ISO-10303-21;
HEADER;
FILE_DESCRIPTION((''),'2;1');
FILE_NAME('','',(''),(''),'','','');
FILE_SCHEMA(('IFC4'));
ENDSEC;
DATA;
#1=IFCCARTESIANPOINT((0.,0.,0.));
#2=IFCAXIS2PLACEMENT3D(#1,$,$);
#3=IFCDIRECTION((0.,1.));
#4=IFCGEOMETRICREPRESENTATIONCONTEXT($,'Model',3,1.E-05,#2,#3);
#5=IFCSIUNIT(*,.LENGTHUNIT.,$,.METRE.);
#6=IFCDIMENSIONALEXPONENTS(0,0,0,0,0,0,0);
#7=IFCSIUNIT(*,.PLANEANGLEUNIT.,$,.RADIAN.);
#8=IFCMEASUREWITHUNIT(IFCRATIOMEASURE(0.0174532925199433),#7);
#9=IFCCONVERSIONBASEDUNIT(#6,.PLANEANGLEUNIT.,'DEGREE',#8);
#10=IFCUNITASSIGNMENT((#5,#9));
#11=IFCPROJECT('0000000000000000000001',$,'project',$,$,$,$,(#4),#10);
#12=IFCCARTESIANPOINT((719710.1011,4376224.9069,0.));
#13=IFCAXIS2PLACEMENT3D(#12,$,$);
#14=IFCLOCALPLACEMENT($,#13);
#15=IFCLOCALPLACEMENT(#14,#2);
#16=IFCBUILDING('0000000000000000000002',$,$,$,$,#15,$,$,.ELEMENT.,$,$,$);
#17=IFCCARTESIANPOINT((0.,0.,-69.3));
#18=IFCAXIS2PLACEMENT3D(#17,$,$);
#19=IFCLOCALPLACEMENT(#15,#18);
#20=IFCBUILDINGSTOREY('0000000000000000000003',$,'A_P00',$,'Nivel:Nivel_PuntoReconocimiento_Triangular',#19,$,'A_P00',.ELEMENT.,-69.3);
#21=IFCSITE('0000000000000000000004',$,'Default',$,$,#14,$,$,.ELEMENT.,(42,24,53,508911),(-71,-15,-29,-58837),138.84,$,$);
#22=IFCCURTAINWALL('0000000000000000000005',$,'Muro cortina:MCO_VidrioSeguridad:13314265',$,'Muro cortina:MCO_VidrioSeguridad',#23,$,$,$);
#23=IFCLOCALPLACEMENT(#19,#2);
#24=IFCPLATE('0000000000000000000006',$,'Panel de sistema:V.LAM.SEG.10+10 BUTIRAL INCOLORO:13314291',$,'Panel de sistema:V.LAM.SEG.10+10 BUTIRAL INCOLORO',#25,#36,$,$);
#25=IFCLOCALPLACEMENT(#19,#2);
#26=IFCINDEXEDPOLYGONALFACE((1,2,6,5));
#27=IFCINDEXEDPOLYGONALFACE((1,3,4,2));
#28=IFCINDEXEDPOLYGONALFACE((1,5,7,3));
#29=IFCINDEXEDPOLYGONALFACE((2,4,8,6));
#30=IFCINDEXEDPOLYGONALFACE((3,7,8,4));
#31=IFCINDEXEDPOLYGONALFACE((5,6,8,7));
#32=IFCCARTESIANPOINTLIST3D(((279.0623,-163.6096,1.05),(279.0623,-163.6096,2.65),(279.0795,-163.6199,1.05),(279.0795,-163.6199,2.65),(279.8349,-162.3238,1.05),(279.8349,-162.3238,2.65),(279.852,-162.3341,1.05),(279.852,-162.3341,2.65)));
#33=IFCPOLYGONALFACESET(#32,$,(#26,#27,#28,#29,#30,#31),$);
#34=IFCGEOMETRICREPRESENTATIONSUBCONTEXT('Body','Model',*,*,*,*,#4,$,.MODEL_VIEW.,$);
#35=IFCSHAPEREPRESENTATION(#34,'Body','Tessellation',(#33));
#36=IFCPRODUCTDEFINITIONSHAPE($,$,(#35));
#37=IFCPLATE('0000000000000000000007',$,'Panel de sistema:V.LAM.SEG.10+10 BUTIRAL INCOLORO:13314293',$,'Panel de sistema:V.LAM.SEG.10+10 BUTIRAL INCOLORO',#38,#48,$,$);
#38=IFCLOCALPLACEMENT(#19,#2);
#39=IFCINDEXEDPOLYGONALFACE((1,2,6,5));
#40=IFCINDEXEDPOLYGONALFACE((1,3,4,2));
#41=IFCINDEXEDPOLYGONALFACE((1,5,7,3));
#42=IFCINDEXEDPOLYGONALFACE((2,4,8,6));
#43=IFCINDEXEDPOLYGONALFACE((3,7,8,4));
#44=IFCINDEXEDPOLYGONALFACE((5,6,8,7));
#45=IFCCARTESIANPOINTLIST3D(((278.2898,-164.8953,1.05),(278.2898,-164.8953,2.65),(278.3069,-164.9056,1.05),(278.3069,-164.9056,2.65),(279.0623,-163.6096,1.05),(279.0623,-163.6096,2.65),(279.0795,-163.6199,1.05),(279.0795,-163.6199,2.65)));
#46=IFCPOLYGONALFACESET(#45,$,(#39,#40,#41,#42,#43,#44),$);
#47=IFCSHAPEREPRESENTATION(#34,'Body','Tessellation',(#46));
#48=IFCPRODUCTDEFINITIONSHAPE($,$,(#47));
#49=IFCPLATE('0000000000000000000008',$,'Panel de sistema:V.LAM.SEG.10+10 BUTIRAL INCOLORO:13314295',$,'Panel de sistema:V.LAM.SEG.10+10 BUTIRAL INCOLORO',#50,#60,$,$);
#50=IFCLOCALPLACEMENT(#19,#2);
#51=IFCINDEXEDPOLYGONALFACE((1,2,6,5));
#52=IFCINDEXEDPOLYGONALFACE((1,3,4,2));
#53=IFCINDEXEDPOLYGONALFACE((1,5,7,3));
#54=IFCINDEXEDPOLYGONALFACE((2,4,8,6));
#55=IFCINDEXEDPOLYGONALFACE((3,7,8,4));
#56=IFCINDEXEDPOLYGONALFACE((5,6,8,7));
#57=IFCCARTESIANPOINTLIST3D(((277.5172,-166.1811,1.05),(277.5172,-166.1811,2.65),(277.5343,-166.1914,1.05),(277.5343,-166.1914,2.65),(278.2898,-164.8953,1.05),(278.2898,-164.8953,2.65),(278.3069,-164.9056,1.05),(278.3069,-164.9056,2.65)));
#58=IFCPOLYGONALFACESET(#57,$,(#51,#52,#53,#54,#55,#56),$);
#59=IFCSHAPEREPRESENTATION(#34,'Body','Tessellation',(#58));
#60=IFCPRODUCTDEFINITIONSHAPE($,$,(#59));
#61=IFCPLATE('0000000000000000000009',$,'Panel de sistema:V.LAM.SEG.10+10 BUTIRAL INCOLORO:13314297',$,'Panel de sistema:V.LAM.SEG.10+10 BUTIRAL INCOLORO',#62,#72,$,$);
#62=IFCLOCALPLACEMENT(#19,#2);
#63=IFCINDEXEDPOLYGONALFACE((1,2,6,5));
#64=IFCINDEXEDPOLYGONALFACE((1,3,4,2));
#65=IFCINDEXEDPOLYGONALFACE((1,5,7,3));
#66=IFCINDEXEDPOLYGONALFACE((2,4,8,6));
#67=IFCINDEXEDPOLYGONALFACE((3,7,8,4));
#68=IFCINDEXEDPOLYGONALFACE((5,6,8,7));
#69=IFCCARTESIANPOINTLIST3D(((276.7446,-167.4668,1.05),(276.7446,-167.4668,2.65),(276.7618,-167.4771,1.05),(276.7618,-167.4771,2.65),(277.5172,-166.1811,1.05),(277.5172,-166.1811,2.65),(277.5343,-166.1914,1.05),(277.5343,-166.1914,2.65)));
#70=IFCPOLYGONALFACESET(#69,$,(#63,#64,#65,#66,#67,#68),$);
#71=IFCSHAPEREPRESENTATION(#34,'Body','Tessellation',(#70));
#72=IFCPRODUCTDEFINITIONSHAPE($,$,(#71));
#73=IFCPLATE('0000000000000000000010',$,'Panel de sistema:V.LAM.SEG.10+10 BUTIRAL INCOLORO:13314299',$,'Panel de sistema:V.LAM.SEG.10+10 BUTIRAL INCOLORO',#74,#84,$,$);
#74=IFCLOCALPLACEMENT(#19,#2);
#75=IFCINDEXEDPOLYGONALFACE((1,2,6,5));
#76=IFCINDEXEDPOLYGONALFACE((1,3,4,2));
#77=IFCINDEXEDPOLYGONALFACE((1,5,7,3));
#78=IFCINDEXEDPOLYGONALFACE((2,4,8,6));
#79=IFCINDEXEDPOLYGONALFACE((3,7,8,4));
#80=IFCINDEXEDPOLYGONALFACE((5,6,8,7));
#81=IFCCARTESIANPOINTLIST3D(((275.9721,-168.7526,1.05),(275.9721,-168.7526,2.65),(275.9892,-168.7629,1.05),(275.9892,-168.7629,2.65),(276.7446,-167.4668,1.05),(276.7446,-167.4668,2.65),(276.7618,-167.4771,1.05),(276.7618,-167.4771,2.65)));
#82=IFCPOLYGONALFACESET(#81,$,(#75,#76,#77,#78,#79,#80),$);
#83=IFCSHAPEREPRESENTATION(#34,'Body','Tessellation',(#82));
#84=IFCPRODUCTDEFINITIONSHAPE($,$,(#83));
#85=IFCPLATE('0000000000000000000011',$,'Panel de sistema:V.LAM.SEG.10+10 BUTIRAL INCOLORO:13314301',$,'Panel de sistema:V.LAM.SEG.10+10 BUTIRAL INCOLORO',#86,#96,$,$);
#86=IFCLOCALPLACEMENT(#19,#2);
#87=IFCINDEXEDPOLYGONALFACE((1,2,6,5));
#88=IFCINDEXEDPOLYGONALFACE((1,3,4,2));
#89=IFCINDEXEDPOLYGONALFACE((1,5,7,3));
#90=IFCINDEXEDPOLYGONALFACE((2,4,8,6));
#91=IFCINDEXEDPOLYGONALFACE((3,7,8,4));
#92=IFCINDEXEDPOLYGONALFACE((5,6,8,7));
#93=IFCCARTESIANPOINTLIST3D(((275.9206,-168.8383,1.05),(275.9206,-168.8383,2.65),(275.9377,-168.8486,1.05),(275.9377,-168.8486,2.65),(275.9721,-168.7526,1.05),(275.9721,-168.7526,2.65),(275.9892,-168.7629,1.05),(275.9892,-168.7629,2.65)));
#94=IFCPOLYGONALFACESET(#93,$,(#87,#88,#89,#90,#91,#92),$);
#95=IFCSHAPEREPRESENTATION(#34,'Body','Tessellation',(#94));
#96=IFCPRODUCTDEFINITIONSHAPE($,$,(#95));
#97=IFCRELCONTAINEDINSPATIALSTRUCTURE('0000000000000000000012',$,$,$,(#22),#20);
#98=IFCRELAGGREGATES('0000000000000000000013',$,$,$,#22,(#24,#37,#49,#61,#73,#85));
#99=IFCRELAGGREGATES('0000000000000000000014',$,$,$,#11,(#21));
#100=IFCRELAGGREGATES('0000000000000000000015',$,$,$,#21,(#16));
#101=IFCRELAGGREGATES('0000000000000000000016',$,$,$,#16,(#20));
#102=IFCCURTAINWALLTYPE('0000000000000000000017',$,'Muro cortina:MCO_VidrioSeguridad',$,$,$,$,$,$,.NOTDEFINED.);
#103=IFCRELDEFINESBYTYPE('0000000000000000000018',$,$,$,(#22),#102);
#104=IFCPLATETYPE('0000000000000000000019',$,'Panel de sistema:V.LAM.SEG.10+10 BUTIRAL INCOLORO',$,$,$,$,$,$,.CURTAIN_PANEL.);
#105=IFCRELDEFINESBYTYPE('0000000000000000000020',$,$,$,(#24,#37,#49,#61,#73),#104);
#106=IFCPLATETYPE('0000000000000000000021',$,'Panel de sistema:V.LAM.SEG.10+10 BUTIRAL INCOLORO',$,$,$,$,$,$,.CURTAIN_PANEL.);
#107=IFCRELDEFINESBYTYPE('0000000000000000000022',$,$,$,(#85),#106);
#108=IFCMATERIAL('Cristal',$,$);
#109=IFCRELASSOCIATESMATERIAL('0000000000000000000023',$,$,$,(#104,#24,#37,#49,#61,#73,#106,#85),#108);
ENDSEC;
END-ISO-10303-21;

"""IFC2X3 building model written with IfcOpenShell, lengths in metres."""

from ifc_helpers import new_model, entity, si_unit, converted_unit, direction, frame, frame_2d, origin, origin_2d_with_axis, place, context, subcontext, project, spatial, rectangle, extrude, source, transform, mapped, material, type_object, type_shapes, element, aggregate, save


model = new_model("IFC2X3")

# Units and contexts
model_context = context("Model", 3, precision=1e-05, world=origin(), true_north=direction((0.0, 1.0)))
body_context = subcontext(model_context, "Body", "Model", "MODEL_VIEW")
ifc_project = project(units=[si_unit("LENGTHUNIT", "METRE"), converted_unit("PLANEANGLEUNIT", "DEGREE", entity("IfcRatioMeasure", 0.0174532925199433), si_unit("PLANEANGLEUNIT", "RADIAN"), dimensions=[0, 0, 0, 0, 0, 0, 0])], contexts=[model_context])

# Site, building, storey
site_placement = place(None, frame((719710.1011, 4376224.9069, 0.0)))
site = spatial("IfcSite", under=ifc_project, at=site_placement, Name="Default", CompositionType="ELEMENT", RefLatitude=(42, 24, 53, 508911), RefLongitude=(-71, -15, -29, -58837), RefElevation=138.84)
building_placement = place(site_placement, origin())
building = spatial("IfcBuilding", under=site, at=building_placement, CompositionType="ELEMENT")
storey_placement = place(building_placement, frame((0.0, 0.0, -69.3)))
storey = spatial("IfcBuildingStorey", under=building, at=storey_placement, Name="A_P00", ObjectType="Nivel:Nivel_PuntoReconocimiento_Triangular", LongName="A_P00", CompositionType="ELEMENT", Elevation=-69.3)

# Curtain wall, plates
curtain_wall_type = type_object("IfcCurtainWallType", Name="Muro cortina:MCO_VidrioSeguridad", PredefinedType="NOTDEFINED")
ifc_material_1 = material(Name="Cristal")
curtain_wall_1_placement = place(storey_placement, frame((0.0, 0.0, 69.3)))
curtain_wall_1 = element("IfcCurtainWall", 1, at=curtain_wall_1_placement, inside=storey, type_object=curtain_wall_type, Name="Muro cortina:MCO_VidrioSeguridad:13314265", ObjectType="Muro cortina:MCO_VidrioSeguridad")
plate_type_1 = type_object("IfcPlateType", Name="Panel de sistema:V.LAM.SEG.10+10 BUTIRAL INCOLORO", PredefinedType="CURTAIN_PANEL", material=ifc_material_1)
shared_shape_1 = source(origin(), body_context, "Body", "SweptSolid", [
    extrude(rectangle(XDim=0.02, YDim=1.5, at=frame_2d((0.0, 0.0), x_axis=(1.0, 0.0))), frame((0.0, 0.0, 0.0), z_axis=(0.0, 0.0, 1.0), x_axis=(0.0, 1.0, 0.0)), (0.0, 0.0, 1.0), 1.6),
])
type_shapes(plate_type_1, [shared_shape_1])
plate_1_placement = place(curtain_wall_1_placement, frame((279.4572, -162.9718, -68.25), z_axis=(0.0, 0.0, 1.0), x_axis=(-0.515038, -0.857167, 0.0)))
plate_1 = element("IfcPlate", 2, at=plate_1_placement, type_object=plate_type_1, material=ifc_material_1, Name="Panel de sistema:V.LAM.SEG.10+10 BUTIRAL INCOLORO:13314291", ObjectType="Panel de sistema:V.LAM.SEG.10+10 BUTIRAL INCOLORO", context=body_context, shape_type="MappedRepresentation", body=[
    mapped(shared_shape_1, transform((0.0, 0.0, 0.0), scale=1.0)),
])
plate_2_placement = place(curtain_wall_1_placement, frame((278.6846, -164.2576, -68.25), z_axis=(0.0, 0.0, 1.0), x_axis=(-0.515038, -0.857167, 0.0)))
plate_2 = element("IfcPlate", 3, at=plate_2_placement, type_object=plate_type_1, material=ifc_material_1, Name="Panel de sistema:V.LAM.SEG.10+10 BUTIRAL INCOLORO:13314293", ObjectType="Panel de sistema:V.LAM.SEG.10+10 BUTIRAL INCOLORO", context=body_context, shape_type="MappedRepresentation", body=[
    mapped(shared_shape_1, transform((0.0, 0.0, 0.0), scale=1.0)),
])
plate_3_placement = place(curtain_wall_1_placement, frame((277.9121, -165.5433, -68.25), z_axis=(0.0, 0.0, 1.0), x_axis=(-0.515038, -0.857167, 0.0)))
plate_3 = element("IfcPlate", 4, at=plate_3_placement, type_object=plate_type_1, material=ifc_material_1, Name="Panel de sistema:V.LAM.SEG.10+10 BUTIRAL INCOLORO:13314295", ObjectType="Panel de sistema:V.LAM.SEG.10+10 BUTIRAL INCOLORO", context=body_context, shape_type="MappedRepresentation", body=[
    mapped(shared_shape_1, transform((0.0, 0.0, 0.0), scale=1.0)),
])
plate_4_placement = place(curtain_wall_1_placement, frame((277.1395, -166.8291, -68.25), z_axis=(0.0, 0.0, 1.0), x_axis=(-0.515038, -0.857167, 0.0)))
plate_4 = element("IfcPlate", 5, at=plate_4_placement, type_object=plate_type_1, material=ifc_material_1, Name="Panel de sistema:V.LAM.SEG.10+10 BUTIRAL INCOLORO:13314297", ObjectType="Panel de sistema:V.LAM.SEG.10+10 BUTIRAL INCOLORO", context=body_context, shape_type="MappedRepresentation", body=[
    mapped(shared_shape_1, transform((0.0, 0.0, 0.0), scale=1.0)),
])
plate_5_placement = place(curtain_wall_1_placement, frame((276.3669, -168.1148, -68.25), z_axis=(0.0, 0.0, 1.0), x_axis=(-0.515038, -0.857167, 0.0)))
plate_5 = element("IfcPlate", 6, at=plate_5_placement, type_object=plate_type_1, material=ifc_material_1, Name="Panel de sistema:V.LAM.SEG.10+10 BUTIRAL INCOLORO:13314299", ObjectType="Panel de sistema:V.LAM.SEG.10+10 BUTIRAL INCOLORO", context=body_context, shape_type="MappedRepresentation", body=[
    mapped(shared_shape_1, transform((0.0, 0.0, 0.0), scale=1.0)),
])
plate_type_2 = type_object("IfcPlateType", Name="Panel de sistema:V.LAM.SEG.10+10 BUTIRAL INCOLORO", PredefinedType="CURTAIN_PANEL", material=ifc_material_1)
shared_shape_2 = source(origin(), body_context, "Body", "SweptSolid", [
    extrude(rectangle(XDim=0.02, YDim=0.1, at=origin_2d_with_axis()), frame((0.0, 0.0, 0.0), z_axis=(0.0, 0.0, 1.0), x_axis=(0.0, 1.0, 0.0)), (0.0, 0.0, 1.0), 1.6),
])
type_shapes(plate_type_2, [shared_shape_2])
plate_6_placement = place(curtain_wall_1_placement, frame((275.9549, -168.8006, -68.25), z_axis=(0.0, 0.0, 1.0), x_axis=(-0.515038, -0.857167, 0.0)))
plate_6 = element("IfcPlate", 7, at=plate_6_placement, type_object=plate_type_2, material=ifc_material_1, Name="Panel de sistema:V.LAM.SEG.10+10 BUTIRAL INCOLORO:13314301", ObjectType="Panel de sistema:V.LAM.SEG.10+10 BUTIRAL INCOLORO", context=body_context, shape_type="MappedRepresentation", body=[
    mapped(shared_shape_2, transform((0.0, 0.0, 0.0), scale=1.0)),
])
aggregate(curtain_wall_1, [plate_1, plate_2, plate_3, plate_4, plate_5, plate_6])

save(model, "model.ifc")
